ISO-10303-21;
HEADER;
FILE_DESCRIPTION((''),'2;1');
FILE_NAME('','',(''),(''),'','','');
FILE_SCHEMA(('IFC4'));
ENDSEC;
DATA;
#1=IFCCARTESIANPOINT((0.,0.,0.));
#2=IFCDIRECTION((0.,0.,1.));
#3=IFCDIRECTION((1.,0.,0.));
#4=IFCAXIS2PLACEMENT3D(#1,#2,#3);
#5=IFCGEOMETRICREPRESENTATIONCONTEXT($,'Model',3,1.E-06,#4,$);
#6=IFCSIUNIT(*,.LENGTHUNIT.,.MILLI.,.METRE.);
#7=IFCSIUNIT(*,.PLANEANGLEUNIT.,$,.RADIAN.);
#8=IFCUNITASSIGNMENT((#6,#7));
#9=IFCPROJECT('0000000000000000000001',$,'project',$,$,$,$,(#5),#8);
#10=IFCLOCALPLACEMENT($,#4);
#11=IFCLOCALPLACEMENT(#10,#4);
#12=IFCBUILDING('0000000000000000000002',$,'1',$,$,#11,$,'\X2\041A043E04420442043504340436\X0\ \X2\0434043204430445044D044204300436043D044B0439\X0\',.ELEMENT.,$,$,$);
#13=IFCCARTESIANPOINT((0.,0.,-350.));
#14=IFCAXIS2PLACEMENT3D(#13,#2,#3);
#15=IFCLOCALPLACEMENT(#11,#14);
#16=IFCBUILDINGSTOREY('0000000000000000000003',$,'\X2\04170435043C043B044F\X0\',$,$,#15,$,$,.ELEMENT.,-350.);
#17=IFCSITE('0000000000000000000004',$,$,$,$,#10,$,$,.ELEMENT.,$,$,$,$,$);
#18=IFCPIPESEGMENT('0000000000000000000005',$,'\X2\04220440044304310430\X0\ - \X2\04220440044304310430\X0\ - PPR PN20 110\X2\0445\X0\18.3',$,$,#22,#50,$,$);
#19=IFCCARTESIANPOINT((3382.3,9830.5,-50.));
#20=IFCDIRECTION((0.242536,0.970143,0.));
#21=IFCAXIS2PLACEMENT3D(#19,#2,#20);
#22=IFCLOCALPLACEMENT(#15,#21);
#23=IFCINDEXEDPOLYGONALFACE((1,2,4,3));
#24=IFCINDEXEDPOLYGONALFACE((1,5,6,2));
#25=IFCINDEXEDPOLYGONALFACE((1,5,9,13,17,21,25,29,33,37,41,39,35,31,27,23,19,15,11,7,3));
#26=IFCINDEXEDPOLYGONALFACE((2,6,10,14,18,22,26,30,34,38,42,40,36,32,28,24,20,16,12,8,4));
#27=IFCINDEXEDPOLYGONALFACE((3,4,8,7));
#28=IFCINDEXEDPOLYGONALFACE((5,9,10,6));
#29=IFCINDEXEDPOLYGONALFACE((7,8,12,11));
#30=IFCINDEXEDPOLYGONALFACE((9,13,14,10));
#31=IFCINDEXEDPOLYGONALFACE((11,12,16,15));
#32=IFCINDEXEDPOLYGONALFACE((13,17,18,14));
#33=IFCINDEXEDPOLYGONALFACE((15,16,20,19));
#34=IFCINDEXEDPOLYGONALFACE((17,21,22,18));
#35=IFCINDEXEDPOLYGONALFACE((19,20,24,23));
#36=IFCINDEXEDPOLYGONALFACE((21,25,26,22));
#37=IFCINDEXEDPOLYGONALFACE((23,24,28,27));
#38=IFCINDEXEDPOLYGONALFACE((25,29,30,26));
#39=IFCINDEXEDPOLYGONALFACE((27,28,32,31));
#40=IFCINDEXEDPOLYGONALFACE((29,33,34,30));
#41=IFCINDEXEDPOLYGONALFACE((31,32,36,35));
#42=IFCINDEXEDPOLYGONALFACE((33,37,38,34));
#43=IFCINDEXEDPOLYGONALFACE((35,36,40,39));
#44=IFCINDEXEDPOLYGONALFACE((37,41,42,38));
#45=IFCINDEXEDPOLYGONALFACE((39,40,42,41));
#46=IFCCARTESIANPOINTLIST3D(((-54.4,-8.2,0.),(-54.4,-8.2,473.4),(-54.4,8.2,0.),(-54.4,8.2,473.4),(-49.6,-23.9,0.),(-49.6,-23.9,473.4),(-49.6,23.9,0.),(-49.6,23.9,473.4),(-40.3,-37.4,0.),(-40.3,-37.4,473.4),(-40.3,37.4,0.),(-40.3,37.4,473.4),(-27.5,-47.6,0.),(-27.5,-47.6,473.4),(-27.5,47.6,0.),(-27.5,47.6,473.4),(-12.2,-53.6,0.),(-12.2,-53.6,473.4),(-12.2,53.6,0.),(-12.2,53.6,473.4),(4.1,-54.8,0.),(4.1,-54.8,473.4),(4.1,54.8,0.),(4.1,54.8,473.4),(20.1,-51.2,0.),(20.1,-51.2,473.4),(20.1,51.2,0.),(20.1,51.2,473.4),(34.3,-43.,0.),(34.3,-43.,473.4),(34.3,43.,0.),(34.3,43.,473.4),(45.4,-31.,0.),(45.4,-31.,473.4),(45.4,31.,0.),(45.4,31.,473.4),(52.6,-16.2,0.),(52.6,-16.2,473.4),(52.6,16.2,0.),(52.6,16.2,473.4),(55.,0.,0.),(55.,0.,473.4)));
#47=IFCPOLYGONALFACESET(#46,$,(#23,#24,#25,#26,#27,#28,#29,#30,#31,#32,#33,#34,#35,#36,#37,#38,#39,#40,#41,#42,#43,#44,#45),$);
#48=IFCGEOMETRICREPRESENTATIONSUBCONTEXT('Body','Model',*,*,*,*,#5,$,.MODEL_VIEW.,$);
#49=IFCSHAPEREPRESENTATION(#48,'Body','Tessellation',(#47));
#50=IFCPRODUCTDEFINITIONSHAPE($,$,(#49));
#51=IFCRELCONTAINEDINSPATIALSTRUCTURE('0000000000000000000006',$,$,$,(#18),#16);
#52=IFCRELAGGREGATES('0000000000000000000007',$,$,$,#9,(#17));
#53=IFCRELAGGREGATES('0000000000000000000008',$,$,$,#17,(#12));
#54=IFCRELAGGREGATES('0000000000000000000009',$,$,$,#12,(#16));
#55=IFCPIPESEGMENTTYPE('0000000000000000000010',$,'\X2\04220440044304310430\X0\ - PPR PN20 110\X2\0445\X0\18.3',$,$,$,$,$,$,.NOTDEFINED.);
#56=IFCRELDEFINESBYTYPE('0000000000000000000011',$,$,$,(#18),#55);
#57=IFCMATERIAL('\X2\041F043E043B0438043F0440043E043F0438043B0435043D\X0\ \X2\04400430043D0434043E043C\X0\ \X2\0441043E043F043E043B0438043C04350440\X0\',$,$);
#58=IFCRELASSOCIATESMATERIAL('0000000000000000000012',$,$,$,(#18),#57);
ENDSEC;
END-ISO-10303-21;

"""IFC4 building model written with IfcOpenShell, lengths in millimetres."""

from ifc_helpers import new_model, entity, si_unit, frame, origin_with_axes, place, context, subcontext, project, spatial, source, transform, mapped, material, type_object, element, save


model = new_model("IFC4")

# Units and contexts
model_context = context("Model", 3, precision=1e-06, world=origin_with_axes())
body_context = subcontext(model_context, "Body", "Model", "MODEL_VIEW")
ifc_project = project(units=[si_unit("LENGTHUNIT", "METRE", prefix="MILLI"), si_unit("PLANEANGLEUNIT", "RADIAN")], contexts=[model_context])

# Site, building, storey
site_placement = place(None, origin_with_axes())
site = spatial("IfcSite", under=ifc_project, at=site_placement, CompositionType="ELEMENT")
building_placement = place(site_placement, origin_with_axes())
building = spatial("IfcBuilding", under=site, at=building_placement, Name="1", LongName="Коттедж двухэтажный", CompositionType="ELEMENT")
storey_placement = place(building_placement, frame((0.0, 0.0, -350.0), z_axis=(0.0, 0.0, 1.0), x_axis=(1.0, 0.0, 0.0)))
storey = spatial("IfcBuildingStorey", under=building, at=storey_placement, Name="Земля", CompositionType="ELEMENT", Elevation=-350.0)

# Pipe segment
ifc_material = material(Name="Полипропилен рандом сополимер")
pipe_segment_type_1 = type_object("IfcPipeSegmentType", Name="Труба - PPR PN20 110х18.3", PredefinedType="NOTDEFINED")
shared_shape_1 = source(origin_with_axes(), body_context, "Body", "AdvancedSweptSolid", [
    entity("IfcSweptDiskSolid", entity("IfcIndexedPolyCurve", entity("IfcCartesianPointList3D", [[0.0, 0.0, 0.0], [0.0, 0.0, 473.4]]), [entity("IfcLineIndex", [1, 2])]), 55.0),
])
pipe_segment_1_placement = place(storey_placement, frame((3382.3, 9830.5, -50.0), z_axis=(0.0, 0.0, 1.0), x_axis=(0.242536, 0.970143, 0.0)))
element("IfcPipeSegment", 1, at=pipe_segment_1_placement, inside=storey, type_object=pipe_segment_type_1, material=ifc_material, Name="Труба - Труба - PPR PN20 110х18.3", context=body_context, shape_type="MappedRepresentation", body=[
    mapped(shared_shape_1, transform((0.0, 0.0, 0.0), x_axis=(1.0, 0.0, 0.0), y_axis=(0.0, 1.0, 0.0), z_axis=(0.0, 0.0, 1.0), scale=1.0)),
])

save(model, "model.ifc")
